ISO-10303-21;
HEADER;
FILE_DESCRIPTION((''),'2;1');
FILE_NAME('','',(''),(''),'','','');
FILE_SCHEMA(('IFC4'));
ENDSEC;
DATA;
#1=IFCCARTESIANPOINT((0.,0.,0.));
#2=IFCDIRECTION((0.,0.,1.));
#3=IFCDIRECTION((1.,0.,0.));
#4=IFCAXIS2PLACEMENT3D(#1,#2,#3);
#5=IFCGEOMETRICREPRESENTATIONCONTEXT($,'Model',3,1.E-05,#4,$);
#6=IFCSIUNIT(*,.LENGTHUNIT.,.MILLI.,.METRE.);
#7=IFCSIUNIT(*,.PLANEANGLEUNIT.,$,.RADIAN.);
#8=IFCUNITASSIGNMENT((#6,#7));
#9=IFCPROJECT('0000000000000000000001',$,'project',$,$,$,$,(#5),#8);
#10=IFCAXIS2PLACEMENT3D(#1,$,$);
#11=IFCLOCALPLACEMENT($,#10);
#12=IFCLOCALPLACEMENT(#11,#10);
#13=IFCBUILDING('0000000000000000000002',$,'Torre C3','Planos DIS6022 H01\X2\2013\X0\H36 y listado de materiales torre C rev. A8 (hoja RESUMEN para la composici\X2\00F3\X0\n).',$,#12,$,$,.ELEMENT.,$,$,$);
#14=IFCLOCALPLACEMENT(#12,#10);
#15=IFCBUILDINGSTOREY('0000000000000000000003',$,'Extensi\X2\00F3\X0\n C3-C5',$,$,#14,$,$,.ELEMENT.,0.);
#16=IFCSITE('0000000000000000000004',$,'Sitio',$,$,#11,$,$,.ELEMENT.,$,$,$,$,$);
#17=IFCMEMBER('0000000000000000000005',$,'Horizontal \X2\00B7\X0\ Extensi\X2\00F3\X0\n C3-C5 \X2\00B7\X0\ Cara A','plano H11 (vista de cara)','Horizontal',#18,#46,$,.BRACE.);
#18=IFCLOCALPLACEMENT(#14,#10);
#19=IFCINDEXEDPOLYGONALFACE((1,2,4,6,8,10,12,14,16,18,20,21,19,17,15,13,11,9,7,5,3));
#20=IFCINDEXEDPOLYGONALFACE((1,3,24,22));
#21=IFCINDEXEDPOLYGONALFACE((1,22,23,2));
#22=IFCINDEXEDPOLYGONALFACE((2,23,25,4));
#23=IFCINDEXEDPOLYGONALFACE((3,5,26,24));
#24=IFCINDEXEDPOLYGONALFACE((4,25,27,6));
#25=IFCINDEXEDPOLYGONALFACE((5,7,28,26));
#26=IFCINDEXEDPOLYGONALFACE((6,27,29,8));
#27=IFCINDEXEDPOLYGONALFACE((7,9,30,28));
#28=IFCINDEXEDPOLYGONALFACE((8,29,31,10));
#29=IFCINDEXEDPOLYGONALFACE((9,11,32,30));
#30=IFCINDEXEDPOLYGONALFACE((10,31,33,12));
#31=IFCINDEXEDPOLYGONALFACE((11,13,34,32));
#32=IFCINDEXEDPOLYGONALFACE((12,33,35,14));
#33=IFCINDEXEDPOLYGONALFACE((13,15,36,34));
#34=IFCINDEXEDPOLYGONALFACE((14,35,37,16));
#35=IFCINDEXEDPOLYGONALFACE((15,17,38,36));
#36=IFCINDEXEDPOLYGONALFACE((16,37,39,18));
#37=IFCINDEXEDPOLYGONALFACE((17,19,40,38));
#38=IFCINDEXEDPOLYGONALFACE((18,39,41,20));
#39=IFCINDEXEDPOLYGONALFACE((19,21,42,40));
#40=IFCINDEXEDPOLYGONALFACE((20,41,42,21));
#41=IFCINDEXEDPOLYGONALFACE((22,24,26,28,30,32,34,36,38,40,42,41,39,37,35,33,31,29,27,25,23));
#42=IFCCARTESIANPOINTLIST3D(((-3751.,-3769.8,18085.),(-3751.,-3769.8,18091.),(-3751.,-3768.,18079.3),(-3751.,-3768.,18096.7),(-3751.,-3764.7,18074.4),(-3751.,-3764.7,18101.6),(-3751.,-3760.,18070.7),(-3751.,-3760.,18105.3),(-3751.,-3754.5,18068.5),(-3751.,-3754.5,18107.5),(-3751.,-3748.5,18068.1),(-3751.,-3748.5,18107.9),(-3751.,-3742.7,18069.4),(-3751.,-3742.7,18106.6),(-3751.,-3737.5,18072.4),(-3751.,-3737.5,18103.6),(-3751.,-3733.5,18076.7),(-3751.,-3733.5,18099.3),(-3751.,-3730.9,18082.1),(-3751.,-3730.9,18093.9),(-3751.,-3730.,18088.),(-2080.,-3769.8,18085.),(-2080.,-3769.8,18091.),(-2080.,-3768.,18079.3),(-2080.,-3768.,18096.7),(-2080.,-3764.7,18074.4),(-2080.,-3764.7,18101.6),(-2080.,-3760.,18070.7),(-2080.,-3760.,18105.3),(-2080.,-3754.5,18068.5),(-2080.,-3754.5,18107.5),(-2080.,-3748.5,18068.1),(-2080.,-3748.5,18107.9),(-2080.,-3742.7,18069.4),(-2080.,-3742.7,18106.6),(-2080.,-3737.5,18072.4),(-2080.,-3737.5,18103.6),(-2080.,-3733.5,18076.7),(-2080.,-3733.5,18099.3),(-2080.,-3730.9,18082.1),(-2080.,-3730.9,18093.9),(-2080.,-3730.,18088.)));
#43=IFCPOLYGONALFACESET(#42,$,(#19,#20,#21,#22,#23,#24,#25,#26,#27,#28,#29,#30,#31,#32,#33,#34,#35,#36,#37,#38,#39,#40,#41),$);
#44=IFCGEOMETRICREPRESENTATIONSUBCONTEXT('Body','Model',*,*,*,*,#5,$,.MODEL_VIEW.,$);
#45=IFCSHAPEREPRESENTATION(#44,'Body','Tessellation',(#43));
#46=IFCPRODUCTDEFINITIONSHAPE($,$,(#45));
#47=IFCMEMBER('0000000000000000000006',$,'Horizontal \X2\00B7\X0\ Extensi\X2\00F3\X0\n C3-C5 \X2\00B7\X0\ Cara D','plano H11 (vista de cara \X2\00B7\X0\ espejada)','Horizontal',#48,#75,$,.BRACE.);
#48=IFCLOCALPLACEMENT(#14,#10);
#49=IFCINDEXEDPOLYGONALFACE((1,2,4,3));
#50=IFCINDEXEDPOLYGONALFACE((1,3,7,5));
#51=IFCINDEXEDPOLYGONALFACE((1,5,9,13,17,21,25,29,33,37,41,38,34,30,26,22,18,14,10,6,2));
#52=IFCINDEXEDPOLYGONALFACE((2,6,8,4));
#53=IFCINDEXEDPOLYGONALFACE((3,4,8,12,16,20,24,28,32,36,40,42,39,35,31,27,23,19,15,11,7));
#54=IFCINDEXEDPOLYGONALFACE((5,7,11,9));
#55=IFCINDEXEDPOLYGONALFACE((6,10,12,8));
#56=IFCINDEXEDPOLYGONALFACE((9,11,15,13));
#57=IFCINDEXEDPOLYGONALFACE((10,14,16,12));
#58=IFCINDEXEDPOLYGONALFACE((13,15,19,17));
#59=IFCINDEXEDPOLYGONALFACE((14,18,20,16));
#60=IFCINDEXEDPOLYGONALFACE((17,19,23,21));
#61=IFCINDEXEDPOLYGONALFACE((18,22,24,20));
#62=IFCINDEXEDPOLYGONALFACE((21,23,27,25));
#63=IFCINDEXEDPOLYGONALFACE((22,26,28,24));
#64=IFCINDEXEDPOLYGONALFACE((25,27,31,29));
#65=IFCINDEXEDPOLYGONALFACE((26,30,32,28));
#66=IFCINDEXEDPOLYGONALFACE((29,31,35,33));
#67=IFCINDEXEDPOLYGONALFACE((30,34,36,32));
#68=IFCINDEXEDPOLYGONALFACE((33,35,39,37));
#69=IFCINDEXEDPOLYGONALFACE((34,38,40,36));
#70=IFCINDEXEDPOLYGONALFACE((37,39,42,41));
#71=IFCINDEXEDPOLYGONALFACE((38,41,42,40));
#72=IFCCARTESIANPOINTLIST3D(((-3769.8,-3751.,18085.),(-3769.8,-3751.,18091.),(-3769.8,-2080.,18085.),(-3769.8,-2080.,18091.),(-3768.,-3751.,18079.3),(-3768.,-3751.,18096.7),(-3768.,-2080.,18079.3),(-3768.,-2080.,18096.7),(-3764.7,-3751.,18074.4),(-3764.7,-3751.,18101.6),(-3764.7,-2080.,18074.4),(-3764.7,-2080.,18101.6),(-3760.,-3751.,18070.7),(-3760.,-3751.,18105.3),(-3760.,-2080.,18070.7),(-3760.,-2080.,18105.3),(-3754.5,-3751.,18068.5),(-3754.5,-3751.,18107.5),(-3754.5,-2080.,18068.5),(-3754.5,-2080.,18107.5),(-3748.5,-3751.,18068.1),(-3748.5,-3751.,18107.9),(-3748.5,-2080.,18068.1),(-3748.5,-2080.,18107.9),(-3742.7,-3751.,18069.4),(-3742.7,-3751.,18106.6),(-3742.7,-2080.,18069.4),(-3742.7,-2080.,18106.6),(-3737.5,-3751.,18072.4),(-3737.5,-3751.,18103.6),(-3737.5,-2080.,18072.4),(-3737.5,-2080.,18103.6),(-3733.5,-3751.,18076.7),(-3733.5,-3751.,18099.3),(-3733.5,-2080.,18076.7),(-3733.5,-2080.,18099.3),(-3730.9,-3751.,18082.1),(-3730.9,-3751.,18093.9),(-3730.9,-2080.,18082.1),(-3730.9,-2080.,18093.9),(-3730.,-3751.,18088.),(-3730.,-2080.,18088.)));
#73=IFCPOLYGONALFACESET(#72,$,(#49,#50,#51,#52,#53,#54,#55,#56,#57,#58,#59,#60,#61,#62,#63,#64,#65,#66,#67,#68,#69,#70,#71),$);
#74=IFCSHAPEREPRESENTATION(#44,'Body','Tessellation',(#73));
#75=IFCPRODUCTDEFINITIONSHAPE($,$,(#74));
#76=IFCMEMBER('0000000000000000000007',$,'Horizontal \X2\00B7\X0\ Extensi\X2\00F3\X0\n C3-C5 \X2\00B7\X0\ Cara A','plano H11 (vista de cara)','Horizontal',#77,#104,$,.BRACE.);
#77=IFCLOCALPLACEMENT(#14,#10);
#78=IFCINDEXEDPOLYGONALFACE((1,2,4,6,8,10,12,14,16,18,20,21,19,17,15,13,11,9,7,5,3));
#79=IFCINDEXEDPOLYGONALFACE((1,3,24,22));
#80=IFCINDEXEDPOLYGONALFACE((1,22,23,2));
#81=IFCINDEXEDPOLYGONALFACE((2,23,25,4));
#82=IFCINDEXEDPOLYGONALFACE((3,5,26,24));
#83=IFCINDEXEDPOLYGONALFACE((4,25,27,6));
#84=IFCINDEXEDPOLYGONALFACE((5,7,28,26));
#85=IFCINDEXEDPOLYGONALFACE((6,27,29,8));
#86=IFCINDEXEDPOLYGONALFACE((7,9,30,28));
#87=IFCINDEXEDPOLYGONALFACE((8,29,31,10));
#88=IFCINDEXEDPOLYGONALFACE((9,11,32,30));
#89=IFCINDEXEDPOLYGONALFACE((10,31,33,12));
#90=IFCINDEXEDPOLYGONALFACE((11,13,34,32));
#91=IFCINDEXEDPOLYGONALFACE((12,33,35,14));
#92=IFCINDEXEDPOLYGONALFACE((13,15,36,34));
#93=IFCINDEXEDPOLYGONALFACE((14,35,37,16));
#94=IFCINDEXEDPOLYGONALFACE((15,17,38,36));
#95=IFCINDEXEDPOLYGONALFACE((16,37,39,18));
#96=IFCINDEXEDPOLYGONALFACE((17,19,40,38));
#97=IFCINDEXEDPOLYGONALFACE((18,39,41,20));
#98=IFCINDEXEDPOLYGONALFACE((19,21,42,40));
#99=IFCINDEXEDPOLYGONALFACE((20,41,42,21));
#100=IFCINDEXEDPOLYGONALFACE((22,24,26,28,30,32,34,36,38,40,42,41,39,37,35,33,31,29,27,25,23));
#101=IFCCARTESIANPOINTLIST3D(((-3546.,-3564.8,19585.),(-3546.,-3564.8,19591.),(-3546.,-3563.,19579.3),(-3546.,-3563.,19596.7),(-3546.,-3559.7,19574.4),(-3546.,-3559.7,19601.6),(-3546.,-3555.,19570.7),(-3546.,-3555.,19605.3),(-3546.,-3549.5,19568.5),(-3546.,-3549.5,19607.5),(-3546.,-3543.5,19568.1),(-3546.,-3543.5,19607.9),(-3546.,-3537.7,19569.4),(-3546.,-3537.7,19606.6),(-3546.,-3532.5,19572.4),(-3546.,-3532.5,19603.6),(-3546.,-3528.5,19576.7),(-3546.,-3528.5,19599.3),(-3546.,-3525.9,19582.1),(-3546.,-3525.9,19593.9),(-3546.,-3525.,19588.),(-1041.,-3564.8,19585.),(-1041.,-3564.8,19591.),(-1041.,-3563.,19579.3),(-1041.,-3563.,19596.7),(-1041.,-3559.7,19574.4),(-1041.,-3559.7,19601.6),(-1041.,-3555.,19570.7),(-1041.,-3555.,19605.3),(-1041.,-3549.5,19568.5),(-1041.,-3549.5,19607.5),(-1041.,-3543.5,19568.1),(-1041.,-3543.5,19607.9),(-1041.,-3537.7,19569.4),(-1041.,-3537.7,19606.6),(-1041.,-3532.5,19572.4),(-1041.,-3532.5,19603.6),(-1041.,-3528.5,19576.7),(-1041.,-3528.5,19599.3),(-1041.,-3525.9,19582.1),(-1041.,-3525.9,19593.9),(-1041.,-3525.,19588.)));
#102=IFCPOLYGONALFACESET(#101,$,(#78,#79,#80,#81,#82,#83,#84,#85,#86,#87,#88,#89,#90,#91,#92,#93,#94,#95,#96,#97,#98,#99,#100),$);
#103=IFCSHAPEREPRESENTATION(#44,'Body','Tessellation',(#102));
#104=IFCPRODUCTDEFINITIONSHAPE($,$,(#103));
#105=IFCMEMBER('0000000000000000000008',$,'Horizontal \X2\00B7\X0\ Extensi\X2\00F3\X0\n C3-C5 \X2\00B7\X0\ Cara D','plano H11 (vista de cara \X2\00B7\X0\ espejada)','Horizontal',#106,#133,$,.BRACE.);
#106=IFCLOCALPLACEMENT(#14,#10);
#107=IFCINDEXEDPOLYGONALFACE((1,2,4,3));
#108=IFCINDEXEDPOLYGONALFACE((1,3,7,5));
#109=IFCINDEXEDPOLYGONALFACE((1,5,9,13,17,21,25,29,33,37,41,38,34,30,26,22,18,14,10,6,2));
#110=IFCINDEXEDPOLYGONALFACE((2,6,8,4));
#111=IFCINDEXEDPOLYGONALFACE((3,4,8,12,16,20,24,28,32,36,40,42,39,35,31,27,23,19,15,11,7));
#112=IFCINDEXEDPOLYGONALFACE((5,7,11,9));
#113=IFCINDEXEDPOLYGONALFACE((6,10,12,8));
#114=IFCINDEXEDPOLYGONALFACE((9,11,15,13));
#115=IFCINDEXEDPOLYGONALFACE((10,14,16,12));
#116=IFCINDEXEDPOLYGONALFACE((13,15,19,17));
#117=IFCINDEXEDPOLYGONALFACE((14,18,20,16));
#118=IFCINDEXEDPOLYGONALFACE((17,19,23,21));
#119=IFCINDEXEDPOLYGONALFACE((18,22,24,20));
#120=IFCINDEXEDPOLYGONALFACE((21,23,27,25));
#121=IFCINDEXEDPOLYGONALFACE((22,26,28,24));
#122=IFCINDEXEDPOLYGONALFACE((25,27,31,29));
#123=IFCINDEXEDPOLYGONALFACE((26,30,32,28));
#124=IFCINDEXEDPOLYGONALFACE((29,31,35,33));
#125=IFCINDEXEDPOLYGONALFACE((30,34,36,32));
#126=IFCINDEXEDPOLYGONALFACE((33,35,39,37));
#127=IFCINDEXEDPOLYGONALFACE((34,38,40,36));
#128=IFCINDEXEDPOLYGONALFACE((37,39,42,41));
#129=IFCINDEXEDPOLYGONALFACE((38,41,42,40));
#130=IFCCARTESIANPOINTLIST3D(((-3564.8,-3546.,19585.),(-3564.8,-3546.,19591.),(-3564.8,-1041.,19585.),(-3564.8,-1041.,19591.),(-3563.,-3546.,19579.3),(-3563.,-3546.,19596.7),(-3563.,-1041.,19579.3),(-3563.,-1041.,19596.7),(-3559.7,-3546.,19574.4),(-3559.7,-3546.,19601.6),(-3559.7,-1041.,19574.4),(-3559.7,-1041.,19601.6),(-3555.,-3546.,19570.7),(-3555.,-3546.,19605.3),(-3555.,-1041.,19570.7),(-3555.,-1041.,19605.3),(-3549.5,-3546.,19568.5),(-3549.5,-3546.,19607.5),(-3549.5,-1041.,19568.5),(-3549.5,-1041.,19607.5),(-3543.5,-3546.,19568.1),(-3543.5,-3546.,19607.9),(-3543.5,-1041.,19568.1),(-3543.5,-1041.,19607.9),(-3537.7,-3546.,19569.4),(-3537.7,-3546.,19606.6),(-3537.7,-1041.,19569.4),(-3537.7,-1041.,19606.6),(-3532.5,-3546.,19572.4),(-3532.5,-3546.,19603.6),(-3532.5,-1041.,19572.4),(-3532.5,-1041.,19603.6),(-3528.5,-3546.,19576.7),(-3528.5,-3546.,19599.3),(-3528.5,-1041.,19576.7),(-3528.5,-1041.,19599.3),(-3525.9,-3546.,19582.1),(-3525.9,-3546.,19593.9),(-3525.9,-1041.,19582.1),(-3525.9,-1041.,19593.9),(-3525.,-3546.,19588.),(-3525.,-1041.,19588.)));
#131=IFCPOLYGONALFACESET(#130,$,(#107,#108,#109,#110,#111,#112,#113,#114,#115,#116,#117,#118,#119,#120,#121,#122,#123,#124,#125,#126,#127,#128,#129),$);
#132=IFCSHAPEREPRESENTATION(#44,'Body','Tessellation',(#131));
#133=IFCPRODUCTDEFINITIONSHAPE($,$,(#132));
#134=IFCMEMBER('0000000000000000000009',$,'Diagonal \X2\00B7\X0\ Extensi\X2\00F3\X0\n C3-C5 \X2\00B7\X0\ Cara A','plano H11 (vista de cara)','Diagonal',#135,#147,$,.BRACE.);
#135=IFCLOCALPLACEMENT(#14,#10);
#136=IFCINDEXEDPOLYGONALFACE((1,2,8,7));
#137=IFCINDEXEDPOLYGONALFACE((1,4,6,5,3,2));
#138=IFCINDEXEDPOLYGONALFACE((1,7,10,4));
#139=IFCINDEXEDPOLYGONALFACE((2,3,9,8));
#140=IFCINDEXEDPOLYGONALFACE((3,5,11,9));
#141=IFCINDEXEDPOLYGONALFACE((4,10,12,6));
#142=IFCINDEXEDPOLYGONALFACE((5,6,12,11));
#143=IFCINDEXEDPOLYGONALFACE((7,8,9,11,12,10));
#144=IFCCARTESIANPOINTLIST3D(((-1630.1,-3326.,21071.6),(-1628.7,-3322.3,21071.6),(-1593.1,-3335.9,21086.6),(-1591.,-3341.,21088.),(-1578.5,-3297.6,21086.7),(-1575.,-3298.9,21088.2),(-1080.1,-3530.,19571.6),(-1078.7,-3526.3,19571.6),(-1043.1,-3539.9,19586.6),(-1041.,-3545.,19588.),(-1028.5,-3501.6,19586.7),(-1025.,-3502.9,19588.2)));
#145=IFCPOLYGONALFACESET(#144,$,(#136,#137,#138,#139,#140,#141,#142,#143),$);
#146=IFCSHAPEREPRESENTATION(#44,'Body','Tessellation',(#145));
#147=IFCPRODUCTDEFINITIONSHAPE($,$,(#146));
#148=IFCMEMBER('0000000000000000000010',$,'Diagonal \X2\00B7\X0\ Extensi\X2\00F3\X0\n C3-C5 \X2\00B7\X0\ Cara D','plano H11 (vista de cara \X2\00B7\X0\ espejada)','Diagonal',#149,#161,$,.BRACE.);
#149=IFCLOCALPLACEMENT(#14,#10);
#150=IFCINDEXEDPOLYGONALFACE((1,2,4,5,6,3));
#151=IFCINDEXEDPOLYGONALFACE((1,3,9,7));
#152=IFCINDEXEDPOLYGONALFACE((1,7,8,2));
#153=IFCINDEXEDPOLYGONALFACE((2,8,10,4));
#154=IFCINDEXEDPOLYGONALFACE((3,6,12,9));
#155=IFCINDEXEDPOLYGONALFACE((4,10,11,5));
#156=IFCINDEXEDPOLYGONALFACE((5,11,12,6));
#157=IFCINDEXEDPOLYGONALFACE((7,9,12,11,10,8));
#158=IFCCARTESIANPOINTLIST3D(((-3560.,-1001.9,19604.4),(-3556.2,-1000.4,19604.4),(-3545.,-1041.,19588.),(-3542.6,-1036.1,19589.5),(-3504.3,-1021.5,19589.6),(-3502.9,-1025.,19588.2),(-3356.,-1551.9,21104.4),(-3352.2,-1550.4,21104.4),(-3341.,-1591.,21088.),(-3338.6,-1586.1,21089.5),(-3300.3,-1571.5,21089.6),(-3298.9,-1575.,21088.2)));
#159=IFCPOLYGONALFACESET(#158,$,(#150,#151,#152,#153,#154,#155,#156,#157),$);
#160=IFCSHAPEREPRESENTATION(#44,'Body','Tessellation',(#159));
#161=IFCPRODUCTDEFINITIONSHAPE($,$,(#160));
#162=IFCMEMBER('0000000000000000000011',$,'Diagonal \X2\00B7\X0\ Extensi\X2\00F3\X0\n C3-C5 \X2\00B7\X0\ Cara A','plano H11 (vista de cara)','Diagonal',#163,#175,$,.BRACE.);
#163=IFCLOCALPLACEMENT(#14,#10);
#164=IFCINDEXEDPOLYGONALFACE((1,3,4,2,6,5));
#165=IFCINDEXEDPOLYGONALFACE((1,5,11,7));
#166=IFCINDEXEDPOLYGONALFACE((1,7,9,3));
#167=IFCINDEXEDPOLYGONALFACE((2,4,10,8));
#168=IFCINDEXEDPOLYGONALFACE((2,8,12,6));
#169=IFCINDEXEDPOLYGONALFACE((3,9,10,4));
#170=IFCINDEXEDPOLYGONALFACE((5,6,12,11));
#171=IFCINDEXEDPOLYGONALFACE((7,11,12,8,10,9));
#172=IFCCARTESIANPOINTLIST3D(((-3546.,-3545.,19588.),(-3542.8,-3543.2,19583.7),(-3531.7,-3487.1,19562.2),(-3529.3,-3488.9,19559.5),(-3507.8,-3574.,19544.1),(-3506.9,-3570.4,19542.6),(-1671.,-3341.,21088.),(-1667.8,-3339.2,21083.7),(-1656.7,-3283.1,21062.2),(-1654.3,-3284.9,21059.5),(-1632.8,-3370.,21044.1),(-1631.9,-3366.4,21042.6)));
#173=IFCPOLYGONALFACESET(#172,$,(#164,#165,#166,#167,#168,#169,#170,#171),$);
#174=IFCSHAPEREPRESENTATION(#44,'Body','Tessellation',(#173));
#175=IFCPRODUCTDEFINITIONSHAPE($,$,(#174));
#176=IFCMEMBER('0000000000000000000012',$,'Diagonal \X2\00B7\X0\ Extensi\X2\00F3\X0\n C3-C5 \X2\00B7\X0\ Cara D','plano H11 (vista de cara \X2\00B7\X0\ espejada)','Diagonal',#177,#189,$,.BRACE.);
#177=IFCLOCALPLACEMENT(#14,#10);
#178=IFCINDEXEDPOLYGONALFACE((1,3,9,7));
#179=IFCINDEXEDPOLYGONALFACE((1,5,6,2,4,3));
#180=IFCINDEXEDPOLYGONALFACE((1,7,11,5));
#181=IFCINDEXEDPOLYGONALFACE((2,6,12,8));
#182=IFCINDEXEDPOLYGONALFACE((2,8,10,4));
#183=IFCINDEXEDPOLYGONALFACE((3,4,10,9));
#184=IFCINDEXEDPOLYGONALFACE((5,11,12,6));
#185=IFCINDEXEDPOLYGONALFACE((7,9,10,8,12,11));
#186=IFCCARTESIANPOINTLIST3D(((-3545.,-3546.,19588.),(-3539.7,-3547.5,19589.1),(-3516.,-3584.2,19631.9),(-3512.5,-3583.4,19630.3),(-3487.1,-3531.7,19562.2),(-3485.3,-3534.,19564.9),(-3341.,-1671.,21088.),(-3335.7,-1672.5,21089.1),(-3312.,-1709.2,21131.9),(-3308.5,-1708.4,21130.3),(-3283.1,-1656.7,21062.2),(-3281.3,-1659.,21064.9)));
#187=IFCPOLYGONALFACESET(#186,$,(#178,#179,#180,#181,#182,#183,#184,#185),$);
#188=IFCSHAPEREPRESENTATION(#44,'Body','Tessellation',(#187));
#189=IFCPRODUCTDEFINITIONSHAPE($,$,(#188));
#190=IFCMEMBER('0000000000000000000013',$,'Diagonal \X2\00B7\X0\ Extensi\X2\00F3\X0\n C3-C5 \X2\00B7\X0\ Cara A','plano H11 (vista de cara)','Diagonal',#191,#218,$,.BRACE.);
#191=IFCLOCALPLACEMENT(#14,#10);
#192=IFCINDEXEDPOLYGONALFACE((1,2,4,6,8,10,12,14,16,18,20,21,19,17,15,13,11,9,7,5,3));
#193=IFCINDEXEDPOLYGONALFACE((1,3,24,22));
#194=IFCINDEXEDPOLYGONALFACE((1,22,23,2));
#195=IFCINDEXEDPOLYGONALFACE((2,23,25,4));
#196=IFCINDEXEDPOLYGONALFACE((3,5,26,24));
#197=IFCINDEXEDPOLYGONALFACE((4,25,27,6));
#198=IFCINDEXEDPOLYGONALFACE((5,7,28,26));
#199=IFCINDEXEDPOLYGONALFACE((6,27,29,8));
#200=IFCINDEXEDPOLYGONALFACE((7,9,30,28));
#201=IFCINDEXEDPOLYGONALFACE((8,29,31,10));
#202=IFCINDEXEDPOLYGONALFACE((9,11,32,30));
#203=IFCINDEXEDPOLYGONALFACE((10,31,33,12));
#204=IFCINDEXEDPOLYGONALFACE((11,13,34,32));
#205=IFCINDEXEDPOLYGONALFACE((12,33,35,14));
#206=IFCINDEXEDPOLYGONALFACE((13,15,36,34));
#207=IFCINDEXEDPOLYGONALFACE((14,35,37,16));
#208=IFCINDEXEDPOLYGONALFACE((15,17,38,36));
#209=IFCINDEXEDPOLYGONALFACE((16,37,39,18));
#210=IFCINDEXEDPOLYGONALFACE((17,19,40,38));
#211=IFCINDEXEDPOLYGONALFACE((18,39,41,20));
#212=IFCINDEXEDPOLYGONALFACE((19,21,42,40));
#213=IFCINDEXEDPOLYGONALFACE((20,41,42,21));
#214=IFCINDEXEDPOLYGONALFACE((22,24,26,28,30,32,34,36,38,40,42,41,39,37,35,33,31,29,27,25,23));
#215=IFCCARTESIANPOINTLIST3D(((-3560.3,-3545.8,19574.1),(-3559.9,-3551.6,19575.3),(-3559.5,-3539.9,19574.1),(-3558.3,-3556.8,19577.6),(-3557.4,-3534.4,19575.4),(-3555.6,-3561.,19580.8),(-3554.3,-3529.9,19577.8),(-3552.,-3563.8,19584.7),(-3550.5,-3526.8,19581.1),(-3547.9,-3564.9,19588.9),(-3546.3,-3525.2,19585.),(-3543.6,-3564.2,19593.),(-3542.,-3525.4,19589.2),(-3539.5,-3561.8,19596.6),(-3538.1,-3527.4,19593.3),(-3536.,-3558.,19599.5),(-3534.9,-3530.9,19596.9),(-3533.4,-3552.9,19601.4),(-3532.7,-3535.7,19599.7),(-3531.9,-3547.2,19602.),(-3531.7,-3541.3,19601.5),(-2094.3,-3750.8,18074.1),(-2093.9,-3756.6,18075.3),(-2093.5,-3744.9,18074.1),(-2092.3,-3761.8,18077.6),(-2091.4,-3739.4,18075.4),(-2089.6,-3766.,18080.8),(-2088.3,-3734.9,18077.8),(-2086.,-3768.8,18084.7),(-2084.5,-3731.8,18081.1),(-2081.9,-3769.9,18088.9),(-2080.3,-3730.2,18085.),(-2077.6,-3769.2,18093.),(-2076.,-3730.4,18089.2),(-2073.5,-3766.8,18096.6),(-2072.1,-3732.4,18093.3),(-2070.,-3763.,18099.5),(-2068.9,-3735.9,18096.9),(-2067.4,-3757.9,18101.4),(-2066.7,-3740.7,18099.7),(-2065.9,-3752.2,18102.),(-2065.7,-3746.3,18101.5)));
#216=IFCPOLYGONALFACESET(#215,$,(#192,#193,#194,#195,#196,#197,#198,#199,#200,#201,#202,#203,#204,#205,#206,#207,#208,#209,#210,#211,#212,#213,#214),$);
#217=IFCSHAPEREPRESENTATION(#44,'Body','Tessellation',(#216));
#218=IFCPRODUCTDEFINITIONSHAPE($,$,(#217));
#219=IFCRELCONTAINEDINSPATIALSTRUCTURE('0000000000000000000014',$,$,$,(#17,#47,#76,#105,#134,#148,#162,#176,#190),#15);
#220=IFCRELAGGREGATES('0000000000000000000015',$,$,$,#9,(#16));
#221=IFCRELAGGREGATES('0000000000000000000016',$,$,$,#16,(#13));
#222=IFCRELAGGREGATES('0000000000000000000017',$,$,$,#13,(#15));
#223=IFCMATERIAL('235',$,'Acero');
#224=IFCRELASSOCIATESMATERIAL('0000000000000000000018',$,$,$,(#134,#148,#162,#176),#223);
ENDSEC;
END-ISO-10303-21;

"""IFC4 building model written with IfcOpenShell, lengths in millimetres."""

from ifc_helpers import new_model, si_unit, frame, frame_2d, origin, origin_with_axes, place, context, subcontext, project, spatial, circle, l_section, extrude, material, element, save


model = new_model("IFC4")

# Units and contexts
model_context = context("Model", 3, precision=1e-05, world=origin_with_axes())
body_context = subcontext(model_context, "Body", "Model", "MODEL_VIEW")
ifc_project = project(units=[si_unit("LENGTHUNIT", "METRE", prefix="MILLI"), si_unit("PLANEANGLEUNIT", "RADIAN")], contexts=[model_context])

# Site, building, storey
site_placement = place(None, origin())
site = spatial("IfcSite", under=ifc_project, at=site_placement, Name="Sitio", CompositionType="ELEMENT")
building_placement = place(site_placement, origin())
building = spatial("IfcBuilding", under=site, at=building_placement, Name="Torre C3", Description="Planos DIS6022 H01–H36 y listado de materiales torre C rev. A8 (hoja RESUMEN para la composición).", CompositionType="ELEMENT")
storey_placement = place(building_placement, origin())
storey = spatial("IfcBuildingStorey", under=building, at=storey_placement, Name="Extensión C3-C5", CompositionType="ELEMENT", Elevation=0.0)

# Members
for number, where, z_axis, x_axis, name, description in (
    (1, (-2080.0, -3750.0, 18088.0), (-1.0, 0.0, 0.0), (0.0, 1.0, 0.0), "Horizontal · Extensión C3-C5 · Cara A", "plano H11 (vista de cara)"),
    (2, (-3750.0, -2080.0, 18088.0), (0.0, -1.0, 0.0), (1.0, 0.0, 0.0), "Horizontal · Extensión C3-C5 · Cara D", "plano H11 (vista de cara · espejada)"),
):
    element("IfcMember", number, at=place(storey_placement, frame(where, z_axis=z_axis, x_axis=x_axis)), inside=storey, Name=name, Description=description, ObjectType="Horizontal", PredefinedType="BRACE", context=body_context, shape_type="SweptSolid", body=[
        extrude(circle(Radius=20.0), None, (0.0, 0.0, 1.0), 1671.0),
    ])
for number, where, z_axis, x_axis, name, description in (
    (3, (-1041.0, -3545.0, 19588.0), (-1.0, 0.0, 0.0), (0.0, 1.0, 0.0), "Horizontal · Extensión C3-C5 · Cara A", "plano H11 (vista de cara)"),
    (4, (-3545.0, -1041.0, 19588.0), (0.0, -1.0, 0.0), (1.0, 0.0, 0.0), "Horizontal · Extensión C3-C5 · Cara D", "plano H11 (vista de cara · espejada)"),
):
    element("IfcMember", number, at=place(storey_placement, frame(where, z_axis=z_axis, x_axis=x_axis)), inside=storey, Name=name, Description=description, ObjectType="Horizontal", PredefinedType="BRACE", context=body_context, shape_type="SweptSolid", body=[
        extrude(circle(Radius=20.0), None, (0.0, 0.0, 1.0), 2505.0),
    ])
ifc_material_1 = material(Name="235", Category="Acero")
for number, where, z_axis, x_axis, name, description in (
    (5, (-1041.0, -3545.0, 19588.0), (-0.341482, 0.126659, 0.931315), (0.355803, 0.934555, 0.003362), "Diagonal · Extensión C3-C5 · Cara A", "plano H11 (vista de cara)"),
    (6, (-3545.0, -1041.0, 19588.0), (0.126659, -0.341482, 0.931315), (0.934555, 0.355803, 0.003362), "Diagonal · Extensión C3-C5 · Cara D", "plano H11 (vista de cara · espejada)"),
):
    element("IfcMember", number, at=place(storey_placement, frame(where, z_axis=z_axis, x_axis=x_axis)), inside=storey, material=ifc_material_1, Name=name, Description=description, ObjectType="Diagonal", PredefinedType="BRACE", context=body_context, shape_type="SweptSolid", body=[
        extrude(l_section(Depth=45.0, Width=45.0, Thickness=4.0, at=frame_2d((22.5, 22.5))), None, (0.0, 0.0, 1.0), 1610.6),
    ])
for number, where, z_axis, x_axis, name, description in (
    (7, (-1671.0, -3341.0, 21088.0), (-0.778066, -0.084654, -0.622453), (0.220307, 0.891172, -0.396583), "Diagonal · Extensión C3-C5 · Cara A", "plano H11 (vista de cara)"),
    (8, (-3341.0, -1671.0, 21088.0), (-0.084654, -0.778066, -0.622453), (0.891172, 0.220307, -0.396583), "Diagonal · Extensión C3-C5 · Cara D", "plano H11 (vista de cara · espejada)"),
):
    element("IfcMember", number, at=place(storey_placement, frame(where, z_axis=z_axis, x_axis=x_axis)), inside=storey, material=ifc_material_1, Name=name, Description=description, ObjectType="Diagonal", PredefinedType="BRACE", context=body_context, shape_type="SweptSolid", body=[
        extrude(l_section(Depth=65.0, Width=65.0, Thickness=4.0, at=frame_2d((32.5, 32.5))), None, (0.0, 0.0, 1.0), 2409.8),
    ])
for number, where, z_axis, x_axis, name in (
    (9, (-3546.0, -3545.0, 19588.0), (0.69564, -0.097276, -0.711774), (0.39331, 0.880677, 0.264036), "Diagonal · Extensión C3-C5 · Cara A"),
):
    element("IfcMember", number, at=place(storey_placement, frame(where, z_axis=z_axis, x_axis=x_axis)), inside=storey, Name=name, Description="plano H11 (vista de cara)", ObjectType="Diagonal", PredefinedType="BRACE", context=body_context, shape_type="SweptSolid", body=[
        extrude(circle(Radius=20.0), None, (0.0, 0.0, 1.0), 2107.4),
    ])

save(model, "model.ifc")
